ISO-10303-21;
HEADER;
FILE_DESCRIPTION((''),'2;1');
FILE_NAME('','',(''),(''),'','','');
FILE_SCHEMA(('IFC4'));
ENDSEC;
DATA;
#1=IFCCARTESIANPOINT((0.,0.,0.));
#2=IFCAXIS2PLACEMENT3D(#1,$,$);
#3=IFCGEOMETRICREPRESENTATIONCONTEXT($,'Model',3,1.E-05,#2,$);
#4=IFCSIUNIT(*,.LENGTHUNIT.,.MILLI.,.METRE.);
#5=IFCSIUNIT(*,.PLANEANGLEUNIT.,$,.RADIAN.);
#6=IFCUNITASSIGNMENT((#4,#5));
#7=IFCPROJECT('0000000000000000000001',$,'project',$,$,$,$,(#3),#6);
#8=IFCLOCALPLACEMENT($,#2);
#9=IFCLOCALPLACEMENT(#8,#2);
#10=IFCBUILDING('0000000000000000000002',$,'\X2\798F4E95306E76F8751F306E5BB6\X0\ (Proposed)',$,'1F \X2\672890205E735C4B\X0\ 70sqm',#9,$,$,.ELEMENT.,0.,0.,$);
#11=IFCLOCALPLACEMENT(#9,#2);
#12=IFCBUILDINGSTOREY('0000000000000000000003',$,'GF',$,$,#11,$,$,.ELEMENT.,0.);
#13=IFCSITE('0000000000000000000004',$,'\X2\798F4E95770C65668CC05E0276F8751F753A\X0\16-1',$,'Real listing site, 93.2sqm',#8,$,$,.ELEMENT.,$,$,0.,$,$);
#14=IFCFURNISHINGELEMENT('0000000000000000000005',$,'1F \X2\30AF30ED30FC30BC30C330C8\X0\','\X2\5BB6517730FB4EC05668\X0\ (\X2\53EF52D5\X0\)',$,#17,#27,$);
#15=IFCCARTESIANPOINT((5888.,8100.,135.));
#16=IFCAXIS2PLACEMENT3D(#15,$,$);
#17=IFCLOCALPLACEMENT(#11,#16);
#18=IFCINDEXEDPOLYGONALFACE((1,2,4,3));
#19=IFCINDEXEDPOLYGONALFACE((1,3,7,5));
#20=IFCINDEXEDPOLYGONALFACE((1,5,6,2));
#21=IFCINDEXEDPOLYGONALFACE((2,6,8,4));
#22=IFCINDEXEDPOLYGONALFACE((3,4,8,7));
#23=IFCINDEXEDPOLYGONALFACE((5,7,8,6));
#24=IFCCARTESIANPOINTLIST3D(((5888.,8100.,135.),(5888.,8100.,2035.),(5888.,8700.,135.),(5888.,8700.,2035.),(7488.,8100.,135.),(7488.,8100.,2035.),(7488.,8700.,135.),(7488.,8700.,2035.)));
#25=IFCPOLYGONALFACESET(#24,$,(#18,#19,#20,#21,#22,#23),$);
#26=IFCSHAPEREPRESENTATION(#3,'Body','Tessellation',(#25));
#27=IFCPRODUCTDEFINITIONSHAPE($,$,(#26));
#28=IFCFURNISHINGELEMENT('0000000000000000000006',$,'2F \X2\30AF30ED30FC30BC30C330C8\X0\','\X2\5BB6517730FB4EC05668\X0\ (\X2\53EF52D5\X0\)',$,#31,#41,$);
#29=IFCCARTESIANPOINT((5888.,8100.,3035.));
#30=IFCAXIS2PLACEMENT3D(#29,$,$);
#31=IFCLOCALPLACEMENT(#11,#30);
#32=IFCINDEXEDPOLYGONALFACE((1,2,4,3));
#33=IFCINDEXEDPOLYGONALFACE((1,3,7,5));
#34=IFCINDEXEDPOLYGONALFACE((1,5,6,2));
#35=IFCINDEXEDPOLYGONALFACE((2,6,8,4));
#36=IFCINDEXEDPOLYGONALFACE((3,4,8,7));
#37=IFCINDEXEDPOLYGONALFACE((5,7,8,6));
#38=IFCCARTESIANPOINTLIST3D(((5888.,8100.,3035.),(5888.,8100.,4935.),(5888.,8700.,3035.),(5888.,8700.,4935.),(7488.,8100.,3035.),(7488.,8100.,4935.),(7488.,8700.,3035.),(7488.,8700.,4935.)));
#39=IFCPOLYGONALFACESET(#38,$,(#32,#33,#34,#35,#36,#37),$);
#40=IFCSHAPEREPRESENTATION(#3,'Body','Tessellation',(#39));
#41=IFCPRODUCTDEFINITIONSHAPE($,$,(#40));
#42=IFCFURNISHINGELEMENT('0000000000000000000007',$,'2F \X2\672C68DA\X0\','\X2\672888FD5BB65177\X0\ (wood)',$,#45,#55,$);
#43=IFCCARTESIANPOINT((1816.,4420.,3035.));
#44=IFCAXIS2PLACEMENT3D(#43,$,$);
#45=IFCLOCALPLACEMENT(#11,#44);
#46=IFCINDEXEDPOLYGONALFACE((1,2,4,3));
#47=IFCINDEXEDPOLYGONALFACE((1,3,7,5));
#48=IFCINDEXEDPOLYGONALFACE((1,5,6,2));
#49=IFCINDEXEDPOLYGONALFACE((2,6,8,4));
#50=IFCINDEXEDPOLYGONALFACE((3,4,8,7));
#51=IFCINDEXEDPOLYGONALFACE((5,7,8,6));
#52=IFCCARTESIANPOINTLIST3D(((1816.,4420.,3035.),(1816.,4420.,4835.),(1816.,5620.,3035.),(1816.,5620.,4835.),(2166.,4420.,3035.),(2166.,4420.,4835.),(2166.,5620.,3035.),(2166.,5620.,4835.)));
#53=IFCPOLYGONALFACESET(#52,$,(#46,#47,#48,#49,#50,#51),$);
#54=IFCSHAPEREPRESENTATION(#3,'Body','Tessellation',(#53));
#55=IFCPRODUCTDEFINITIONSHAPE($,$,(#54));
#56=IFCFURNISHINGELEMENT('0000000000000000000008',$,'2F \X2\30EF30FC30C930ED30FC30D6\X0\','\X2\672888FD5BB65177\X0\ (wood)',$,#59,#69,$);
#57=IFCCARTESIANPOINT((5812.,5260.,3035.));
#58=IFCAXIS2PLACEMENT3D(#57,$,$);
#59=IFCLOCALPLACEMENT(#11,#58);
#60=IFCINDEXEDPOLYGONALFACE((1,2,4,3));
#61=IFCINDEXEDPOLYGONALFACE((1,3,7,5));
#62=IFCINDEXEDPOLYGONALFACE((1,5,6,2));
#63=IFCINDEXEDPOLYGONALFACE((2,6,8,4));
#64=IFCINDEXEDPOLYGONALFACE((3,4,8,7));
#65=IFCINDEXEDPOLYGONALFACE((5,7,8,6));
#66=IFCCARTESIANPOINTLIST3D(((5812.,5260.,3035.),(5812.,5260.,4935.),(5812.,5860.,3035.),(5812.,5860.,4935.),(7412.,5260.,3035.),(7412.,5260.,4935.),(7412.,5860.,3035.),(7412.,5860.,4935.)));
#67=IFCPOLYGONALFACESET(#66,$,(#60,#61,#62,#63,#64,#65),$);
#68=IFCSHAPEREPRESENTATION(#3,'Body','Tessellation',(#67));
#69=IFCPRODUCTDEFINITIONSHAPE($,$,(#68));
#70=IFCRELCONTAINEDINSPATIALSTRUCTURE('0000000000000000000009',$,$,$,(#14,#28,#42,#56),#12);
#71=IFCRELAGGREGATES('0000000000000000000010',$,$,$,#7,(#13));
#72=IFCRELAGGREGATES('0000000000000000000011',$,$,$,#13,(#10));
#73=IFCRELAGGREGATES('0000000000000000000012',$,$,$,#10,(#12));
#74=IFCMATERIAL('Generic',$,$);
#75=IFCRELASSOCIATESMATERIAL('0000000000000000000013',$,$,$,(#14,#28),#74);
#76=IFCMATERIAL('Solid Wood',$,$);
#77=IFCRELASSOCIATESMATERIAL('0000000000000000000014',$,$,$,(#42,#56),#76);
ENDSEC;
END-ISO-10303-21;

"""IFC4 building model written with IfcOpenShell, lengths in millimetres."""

from ifc_helpers import new_model, si_unit, frame, frame_2d, origin, place, context, project, spatial, rectangle, extrude, material, element, save


model = new_model("IFC4")

# Units and contexts
model_context = context("Model", 3, precision=1e-05, world=origin())
ifc_project = project(units=[si_unit("LENGTHUNIT", "METRE", prefix="MILLI"), si_unit("PLANEANGLEUNIT", "RADIAN")], contexts=[model_context])

# Site, building, storey
site_placement = place(None, origin())
site = spatial("IfcSite", under=ifc_project, at=site_placement, Name="福井県敦賀市相生町16-1", ObjectType="Real listing site, 93.2sqm", CompositionType="ELEMENT", RefElevation=0.0)
building_placement = place(site_placement, origin())
building = spatial("IfcBuilding", under=site, at=building_placement, Name="福井の相生の家 (Proposed)", ObjectType="1F 木造平屋 70sqm", CompositionType="ELEMENT", ElevationOfRefHeight=0.0, ElevationOfTerrain=0.0)
storey_placement = place(building_placement, origin())
storey = spatial("IfcBuildingStorey", under=building, at=storey_placement, Name="GF", CompositionType="ELEMENT", Elevation=0.0)

# Shared definitions
ifc_material_1 = material(Name="Solid Wood")

# Shared definitions
ifc_material_2 = material(Name="Generic")

# Furnishing elements
furnishing_1_placement = place(storey_placement, frame((5888.0, 8100.0, 135.0)))
element("IfcFurnishingElement", 1, at=furnishing_1_placement, inside=storey, material=ifc_material_2, Name="1F クローゼット", Description="家具・什器 (可動)", context=model_context, shape_type="SweptSolid", body=[
    extrude(rectangle(XDim=1600.0, YDim=600.0, at=frame_2d((800.0, 300.0))), frame((5888.0, 8100.0, 135.0)), (0.0, 0.0, 1.0), 1900.0),
])
furnishing_2_placement = place(storey_placement, frame((5888.0, 8100.0, 3035.0)))
element("IfcFurnishingElement", 2, at=furnishing_2_placement, inside=storey, material=ifc_material_2, Name="2F クローゼット", Description="家具・什器 (可動)", context=model_context, shape_type="SweptSolid", body=[
    extrude(rectangle(XDim=1600.0, YDim=600.0, at=frame_2d((800.0, 300.0))), frame((5888.0, 8100.0, 3035.0)), (0.0, 0.0, 1.0), 1900.0),
])
furnishing_3_placement = place(storey_placement, frame((1816.0, 4420.0, 3035.0)))
element("IfcFurnishingElement", 3, at=furnishing_3_placement, inside=storey, material=ifc_material_1, Name="2F 本棚", Description="木製家具 (wood)", context=model_context, shape_type="SweptSolid", body=[
    extrude(rectangle(XDim=350.0, YDim=1200.0, at=frame_2d((175.0, 600.0))), frame((1816.0, 4420.0, 3035.0)), (0.0, 0.0, 1.0), 1800.0),
])
furnishing_4_placement = place(storey_placement, frame((5812.0, 5260.0, 3035.0)))
element("IfcFurnishingElement", 4, at=furnishing_4_placement, inside=storey, material=ifc_material_1, Name="2F ワードローブ", Description="木製家具 (wood)", context=model_context, shape_type="SweptSolid", body=[
    extrude(rectangle(XDim=1600.0, YDim=600.0, at=frame_2d((800.0, 300.0))), frame((5812.0, 5260.0, 3035.0)), (0.0, 0.0, 1.0), 1900.0),
])

save(model, "model.ifc")
